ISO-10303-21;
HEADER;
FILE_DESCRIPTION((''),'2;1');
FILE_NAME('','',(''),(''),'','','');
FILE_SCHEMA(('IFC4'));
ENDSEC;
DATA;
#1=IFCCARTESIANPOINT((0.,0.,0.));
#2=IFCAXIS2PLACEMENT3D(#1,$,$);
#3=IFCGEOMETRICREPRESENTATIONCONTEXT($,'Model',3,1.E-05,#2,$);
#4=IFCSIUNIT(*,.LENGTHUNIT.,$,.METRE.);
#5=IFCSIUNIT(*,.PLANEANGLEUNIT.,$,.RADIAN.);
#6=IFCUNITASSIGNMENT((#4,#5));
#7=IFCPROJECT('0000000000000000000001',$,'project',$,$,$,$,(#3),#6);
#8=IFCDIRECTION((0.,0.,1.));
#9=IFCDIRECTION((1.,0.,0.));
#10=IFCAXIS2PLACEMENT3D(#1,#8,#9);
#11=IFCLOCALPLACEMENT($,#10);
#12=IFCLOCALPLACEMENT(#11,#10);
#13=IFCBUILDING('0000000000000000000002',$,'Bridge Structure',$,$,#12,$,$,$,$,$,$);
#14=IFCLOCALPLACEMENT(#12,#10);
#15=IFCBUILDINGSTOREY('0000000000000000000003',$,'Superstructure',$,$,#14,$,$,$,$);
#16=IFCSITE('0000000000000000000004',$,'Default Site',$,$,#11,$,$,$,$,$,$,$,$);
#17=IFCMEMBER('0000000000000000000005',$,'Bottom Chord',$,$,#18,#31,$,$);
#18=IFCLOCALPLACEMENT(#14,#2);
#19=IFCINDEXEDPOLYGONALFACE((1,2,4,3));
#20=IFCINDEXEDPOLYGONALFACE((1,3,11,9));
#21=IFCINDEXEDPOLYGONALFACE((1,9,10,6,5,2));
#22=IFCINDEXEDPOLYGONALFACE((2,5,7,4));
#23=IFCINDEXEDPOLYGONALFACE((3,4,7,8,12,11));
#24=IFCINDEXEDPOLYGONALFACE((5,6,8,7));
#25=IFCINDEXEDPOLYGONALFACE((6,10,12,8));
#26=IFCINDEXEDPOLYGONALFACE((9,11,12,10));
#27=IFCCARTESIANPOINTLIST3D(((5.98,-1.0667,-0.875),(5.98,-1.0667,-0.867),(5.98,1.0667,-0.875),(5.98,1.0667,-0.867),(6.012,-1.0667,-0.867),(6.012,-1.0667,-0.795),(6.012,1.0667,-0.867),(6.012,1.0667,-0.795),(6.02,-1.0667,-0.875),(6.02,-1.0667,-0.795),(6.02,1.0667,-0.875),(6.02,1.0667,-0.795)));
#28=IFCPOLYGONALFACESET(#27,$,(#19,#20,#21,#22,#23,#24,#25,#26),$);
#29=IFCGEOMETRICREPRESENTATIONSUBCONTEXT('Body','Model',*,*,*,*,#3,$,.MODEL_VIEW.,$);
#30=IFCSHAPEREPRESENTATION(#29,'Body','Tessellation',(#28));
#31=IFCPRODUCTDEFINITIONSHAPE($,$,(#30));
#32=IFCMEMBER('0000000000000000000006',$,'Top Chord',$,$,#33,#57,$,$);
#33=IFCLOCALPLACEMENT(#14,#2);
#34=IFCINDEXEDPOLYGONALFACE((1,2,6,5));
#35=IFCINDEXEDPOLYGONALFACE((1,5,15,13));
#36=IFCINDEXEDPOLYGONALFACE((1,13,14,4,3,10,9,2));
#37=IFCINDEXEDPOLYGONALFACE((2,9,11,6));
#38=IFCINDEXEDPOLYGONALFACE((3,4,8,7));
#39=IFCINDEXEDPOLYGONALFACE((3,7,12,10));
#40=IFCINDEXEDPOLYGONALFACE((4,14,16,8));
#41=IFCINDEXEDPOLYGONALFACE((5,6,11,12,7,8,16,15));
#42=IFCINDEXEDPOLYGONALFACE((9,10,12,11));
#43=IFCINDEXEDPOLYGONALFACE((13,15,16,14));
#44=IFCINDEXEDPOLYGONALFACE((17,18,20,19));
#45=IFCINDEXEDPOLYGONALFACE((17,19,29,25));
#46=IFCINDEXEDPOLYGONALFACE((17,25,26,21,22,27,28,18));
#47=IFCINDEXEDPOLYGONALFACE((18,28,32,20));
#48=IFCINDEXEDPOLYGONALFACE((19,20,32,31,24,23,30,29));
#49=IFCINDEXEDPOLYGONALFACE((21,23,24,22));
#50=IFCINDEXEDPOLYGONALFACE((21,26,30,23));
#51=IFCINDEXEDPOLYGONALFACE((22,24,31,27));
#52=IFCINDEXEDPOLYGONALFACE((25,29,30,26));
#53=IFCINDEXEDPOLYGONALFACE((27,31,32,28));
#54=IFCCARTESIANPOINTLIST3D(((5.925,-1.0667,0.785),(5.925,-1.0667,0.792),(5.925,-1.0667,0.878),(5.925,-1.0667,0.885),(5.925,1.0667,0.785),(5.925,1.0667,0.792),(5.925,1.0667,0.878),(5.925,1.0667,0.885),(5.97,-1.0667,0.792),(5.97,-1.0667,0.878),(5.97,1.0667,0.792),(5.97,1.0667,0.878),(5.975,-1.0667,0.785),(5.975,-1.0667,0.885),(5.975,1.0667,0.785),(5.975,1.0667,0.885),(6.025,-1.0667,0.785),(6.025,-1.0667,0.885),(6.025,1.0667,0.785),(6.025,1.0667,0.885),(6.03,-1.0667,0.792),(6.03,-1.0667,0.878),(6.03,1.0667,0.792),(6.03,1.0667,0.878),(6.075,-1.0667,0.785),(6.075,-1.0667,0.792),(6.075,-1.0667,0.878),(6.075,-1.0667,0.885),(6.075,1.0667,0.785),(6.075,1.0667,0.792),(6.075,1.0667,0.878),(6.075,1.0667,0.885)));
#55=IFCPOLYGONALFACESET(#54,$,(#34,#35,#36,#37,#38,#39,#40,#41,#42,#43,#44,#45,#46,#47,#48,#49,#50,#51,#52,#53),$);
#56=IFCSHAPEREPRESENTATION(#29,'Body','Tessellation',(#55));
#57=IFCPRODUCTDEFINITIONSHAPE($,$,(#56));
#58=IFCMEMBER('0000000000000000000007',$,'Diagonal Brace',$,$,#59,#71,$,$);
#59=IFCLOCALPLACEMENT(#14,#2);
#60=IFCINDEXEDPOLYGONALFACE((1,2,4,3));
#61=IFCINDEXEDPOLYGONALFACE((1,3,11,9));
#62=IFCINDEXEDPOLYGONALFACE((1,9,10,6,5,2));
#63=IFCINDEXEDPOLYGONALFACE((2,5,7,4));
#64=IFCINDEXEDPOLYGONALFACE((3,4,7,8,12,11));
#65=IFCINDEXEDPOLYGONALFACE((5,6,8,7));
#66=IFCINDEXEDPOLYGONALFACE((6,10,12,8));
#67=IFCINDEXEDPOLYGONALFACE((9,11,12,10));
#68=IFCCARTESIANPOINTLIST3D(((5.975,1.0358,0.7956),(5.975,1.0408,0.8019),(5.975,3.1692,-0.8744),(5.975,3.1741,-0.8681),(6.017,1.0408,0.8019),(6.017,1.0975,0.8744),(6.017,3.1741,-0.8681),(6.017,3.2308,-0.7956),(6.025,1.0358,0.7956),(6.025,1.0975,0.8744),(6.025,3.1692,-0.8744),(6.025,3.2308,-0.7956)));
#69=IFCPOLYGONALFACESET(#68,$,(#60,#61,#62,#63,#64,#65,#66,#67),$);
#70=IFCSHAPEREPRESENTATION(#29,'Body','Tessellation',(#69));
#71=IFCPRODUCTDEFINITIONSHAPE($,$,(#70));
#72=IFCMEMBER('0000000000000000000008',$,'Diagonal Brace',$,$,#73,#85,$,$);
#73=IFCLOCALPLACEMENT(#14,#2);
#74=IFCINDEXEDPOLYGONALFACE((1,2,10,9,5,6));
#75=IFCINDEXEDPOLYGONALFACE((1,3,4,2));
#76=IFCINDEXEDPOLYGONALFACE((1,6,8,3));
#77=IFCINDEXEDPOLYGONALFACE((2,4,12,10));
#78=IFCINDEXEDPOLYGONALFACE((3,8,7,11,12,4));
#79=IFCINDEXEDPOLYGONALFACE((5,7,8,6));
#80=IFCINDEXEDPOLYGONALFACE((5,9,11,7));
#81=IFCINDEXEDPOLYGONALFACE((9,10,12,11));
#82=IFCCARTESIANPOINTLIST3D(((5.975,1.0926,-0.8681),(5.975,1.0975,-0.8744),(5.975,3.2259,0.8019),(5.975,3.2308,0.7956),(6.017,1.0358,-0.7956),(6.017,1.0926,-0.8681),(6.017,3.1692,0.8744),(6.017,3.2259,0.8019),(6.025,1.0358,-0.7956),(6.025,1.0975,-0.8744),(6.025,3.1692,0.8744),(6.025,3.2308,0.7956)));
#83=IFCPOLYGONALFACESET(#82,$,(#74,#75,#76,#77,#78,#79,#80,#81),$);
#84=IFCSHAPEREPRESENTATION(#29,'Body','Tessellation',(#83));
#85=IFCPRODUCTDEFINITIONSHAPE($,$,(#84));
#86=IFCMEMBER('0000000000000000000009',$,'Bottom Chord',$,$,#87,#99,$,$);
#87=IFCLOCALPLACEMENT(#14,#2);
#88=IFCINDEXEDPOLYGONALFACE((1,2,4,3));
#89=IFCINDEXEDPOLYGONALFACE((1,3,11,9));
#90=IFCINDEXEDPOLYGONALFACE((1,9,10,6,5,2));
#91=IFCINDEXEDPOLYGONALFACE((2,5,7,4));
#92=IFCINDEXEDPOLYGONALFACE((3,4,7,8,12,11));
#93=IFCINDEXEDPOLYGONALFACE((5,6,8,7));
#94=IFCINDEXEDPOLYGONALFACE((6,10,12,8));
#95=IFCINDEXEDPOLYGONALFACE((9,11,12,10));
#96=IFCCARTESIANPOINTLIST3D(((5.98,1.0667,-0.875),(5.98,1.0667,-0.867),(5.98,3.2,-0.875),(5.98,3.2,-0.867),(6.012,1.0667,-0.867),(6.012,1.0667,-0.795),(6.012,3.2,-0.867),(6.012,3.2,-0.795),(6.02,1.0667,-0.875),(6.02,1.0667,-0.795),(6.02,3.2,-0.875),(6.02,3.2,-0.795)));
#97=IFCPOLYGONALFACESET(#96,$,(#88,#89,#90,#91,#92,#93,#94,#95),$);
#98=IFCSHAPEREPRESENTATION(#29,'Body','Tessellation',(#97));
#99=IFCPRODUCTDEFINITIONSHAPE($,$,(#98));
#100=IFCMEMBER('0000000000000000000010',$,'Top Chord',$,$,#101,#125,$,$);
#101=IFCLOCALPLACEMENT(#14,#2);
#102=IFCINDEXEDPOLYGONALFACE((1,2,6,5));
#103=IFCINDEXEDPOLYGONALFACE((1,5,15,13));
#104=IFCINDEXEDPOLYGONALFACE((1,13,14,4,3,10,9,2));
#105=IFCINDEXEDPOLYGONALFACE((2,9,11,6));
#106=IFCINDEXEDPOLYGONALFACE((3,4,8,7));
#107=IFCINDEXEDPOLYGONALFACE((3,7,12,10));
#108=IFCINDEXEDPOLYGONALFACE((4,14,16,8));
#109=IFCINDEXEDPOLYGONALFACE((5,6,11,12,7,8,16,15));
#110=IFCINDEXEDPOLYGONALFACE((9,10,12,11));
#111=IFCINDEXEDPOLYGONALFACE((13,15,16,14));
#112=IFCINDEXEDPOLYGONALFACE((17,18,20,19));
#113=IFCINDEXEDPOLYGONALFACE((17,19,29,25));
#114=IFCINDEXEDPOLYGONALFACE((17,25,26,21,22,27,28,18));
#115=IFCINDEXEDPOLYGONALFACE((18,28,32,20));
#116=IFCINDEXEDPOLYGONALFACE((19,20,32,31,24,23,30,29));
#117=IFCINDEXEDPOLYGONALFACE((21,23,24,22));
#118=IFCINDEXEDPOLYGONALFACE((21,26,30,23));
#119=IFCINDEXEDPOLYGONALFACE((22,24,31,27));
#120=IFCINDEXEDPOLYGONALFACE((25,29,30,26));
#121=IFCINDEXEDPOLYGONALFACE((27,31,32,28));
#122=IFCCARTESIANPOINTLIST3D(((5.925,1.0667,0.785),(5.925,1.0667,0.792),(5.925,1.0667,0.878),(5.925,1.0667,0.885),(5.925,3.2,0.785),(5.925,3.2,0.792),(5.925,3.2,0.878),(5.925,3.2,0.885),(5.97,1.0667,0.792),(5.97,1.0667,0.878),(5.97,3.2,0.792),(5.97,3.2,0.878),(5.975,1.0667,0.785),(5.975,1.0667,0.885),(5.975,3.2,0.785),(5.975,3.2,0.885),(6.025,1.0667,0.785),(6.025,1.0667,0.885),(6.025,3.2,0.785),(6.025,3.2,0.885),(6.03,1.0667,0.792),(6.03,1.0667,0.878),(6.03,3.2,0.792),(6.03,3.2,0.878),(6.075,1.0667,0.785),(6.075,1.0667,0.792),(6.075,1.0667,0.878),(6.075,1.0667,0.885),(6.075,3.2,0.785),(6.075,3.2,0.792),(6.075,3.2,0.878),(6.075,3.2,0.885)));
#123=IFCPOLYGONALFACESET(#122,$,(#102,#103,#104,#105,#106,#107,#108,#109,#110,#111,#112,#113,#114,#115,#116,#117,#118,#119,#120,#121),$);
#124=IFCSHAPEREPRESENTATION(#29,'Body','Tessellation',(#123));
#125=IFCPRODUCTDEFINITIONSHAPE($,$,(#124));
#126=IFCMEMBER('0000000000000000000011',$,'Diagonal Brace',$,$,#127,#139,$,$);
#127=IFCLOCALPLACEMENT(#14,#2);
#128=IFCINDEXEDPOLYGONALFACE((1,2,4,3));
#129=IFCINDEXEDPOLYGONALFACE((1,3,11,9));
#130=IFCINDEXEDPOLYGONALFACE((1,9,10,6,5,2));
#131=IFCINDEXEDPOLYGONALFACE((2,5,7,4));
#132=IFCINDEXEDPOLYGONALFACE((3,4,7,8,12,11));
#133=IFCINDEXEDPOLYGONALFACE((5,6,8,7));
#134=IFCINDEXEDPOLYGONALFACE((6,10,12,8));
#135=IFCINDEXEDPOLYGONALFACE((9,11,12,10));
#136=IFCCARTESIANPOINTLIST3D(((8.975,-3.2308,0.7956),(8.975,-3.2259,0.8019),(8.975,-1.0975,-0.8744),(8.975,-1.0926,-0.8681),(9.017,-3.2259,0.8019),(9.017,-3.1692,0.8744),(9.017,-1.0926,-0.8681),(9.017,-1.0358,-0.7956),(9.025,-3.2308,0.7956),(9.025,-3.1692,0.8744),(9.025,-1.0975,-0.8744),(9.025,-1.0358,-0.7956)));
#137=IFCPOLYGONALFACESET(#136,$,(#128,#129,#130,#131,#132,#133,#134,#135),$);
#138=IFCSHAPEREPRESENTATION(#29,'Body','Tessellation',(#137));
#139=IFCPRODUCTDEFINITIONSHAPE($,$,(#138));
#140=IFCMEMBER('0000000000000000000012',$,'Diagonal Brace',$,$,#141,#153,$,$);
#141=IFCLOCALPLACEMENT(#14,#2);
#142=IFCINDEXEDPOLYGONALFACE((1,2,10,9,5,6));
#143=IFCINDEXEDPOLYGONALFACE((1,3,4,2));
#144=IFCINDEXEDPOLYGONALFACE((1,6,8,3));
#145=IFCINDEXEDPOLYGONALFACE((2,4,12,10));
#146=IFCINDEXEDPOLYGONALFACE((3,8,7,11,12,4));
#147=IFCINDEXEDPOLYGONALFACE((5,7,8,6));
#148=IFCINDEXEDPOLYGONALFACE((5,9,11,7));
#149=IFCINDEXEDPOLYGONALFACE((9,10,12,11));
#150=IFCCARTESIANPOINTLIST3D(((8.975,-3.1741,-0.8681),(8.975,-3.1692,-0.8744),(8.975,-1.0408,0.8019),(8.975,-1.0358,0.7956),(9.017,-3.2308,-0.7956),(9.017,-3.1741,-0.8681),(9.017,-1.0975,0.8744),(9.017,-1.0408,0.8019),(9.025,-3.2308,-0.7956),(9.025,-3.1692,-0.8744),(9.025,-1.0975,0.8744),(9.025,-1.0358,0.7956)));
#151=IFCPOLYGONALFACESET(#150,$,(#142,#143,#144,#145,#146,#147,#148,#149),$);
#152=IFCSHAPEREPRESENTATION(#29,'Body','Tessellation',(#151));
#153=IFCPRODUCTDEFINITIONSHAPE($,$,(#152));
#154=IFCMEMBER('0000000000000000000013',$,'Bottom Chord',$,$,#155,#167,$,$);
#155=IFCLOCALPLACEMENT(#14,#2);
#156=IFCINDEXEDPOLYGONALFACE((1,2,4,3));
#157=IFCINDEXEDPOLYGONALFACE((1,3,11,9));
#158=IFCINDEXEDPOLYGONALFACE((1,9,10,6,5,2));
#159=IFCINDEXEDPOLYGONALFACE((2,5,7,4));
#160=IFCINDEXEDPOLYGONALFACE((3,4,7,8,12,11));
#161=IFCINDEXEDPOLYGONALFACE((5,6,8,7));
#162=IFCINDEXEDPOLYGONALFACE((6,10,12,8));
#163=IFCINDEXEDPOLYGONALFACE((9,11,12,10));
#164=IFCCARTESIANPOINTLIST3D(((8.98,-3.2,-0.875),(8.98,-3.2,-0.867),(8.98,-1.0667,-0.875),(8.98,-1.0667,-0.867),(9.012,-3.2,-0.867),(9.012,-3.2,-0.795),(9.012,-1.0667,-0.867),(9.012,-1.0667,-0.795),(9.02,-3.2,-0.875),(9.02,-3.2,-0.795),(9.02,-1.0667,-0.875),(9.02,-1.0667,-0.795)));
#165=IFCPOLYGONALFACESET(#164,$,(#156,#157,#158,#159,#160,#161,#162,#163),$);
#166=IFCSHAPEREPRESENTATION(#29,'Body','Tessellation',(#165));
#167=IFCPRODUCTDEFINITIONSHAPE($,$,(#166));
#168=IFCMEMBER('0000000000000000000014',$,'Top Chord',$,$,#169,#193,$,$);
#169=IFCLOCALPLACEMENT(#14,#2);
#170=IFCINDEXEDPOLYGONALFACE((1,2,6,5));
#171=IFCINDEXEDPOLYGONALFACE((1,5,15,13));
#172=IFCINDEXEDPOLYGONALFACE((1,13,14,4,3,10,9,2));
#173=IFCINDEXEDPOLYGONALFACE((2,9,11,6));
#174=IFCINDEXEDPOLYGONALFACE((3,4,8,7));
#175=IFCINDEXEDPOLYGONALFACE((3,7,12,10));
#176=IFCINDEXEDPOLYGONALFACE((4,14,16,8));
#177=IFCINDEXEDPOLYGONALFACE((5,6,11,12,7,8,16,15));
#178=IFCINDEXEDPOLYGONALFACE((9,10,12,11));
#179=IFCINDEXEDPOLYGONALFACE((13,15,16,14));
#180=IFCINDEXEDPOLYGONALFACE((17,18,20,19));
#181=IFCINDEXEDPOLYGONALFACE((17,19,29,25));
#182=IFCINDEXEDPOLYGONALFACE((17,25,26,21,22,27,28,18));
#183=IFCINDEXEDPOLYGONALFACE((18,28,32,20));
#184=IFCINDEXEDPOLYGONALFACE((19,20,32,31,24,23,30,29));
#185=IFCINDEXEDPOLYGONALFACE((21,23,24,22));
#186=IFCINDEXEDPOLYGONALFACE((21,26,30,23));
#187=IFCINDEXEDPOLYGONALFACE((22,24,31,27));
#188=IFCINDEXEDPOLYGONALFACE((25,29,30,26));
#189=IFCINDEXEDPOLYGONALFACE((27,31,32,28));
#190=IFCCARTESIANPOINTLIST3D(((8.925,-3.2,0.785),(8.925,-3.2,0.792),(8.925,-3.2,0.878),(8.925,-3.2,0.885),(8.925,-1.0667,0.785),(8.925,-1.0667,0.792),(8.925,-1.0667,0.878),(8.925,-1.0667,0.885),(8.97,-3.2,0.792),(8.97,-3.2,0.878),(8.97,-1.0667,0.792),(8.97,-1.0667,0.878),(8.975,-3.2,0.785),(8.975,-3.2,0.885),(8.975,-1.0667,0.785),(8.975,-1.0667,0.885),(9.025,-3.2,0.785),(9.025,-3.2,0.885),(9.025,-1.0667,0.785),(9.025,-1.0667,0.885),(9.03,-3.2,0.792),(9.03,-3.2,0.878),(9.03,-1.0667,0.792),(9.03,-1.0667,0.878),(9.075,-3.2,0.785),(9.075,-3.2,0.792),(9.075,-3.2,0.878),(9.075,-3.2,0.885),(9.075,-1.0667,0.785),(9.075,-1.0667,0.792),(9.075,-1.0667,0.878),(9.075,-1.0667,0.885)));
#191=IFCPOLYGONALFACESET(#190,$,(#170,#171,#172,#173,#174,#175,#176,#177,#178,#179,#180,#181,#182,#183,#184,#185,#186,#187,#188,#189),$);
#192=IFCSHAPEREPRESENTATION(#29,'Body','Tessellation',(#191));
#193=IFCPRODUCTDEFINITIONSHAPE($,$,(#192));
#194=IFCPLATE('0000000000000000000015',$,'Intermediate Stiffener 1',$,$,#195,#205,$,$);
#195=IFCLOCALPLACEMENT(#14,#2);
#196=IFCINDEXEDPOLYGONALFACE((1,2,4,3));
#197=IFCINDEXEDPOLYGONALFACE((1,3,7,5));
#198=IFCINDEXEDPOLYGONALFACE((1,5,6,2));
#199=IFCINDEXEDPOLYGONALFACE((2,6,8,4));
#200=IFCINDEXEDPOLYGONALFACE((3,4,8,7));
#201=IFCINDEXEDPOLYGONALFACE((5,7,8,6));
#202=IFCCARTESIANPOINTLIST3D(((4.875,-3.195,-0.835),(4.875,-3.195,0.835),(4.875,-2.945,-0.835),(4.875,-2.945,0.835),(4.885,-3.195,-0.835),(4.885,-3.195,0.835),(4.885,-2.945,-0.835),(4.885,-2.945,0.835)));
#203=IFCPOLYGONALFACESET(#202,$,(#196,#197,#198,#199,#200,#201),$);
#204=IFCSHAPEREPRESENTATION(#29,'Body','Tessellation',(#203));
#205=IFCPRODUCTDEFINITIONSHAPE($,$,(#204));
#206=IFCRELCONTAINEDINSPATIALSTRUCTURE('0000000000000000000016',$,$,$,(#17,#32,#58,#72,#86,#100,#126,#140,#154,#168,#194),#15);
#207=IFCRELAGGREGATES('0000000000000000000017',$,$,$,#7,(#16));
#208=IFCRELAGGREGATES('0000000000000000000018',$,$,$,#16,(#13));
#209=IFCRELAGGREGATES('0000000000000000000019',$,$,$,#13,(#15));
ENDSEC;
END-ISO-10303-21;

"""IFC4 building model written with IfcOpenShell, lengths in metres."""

from ifc_helpers import new_model, si_unit, frame, origin, origin_with_axes, origin_2d_with_axis, place, context, subcontext, project, spatial, polyline, rectangle, l_section, outline, composite_profile, extrude, element, save


model = new_model("IFC4")

# Units and contexts
model_context = context("Model", 3, precision=1e-05, world=origin())
body_context = subcontext(model_context, "Body", "Model", "MODEL_VIEW")
ifc_project = project(units=[si_unit("LENGTHUNIT", "METRE"), si_unit("PLANEANGLEUNIT", "RADIAN")], contexts=[model_context])

# Site, building, storey
site_placement = place(None, origin_with_axes())
site = spatial("IfcSite", under=ifc_project, at=site_placement, Name="Default Site")
building_placement = place(site_placement, origin_with_axes())
building = spatial("IfcBuilding", under=site, at=building_placement, Name="Bridge Structure")
storey_placement = place(building_placement, origin_with_axes())
storey = spatial("IfcBuildingStorey", under=building, at=storey_placement, Name="Superstructure")

# Members
member_1_placement = place(storey_placement, frame((6.0, -1.0667, -0.835), z_axis=(0.0, 1.0, 0.0), x_axis=(-1.0, 0.0, 0.0)))
element("IfcMember", 1, at=member_1_placement, inside=storey, Name="Bottom Chord", context=body_context, shape_type="SweptSolid", body=[
    extrude(l_section(Depth=0.08, Width=0.04, Thickness=0.008, at=origin_2d_with_axis()), origin_with_axes(), (0.0, 0.0, 1.0), 2.1333),
])
member_2_placement = place(storey_placement, frame((6.0, -1.0667, 0.835), z_axis=(0.0, 1.0, 0.0), x_axis=(-1.0, 0.0, 0.0)))
element("IfcMember", 2, at=member_2_placement, inside=storey, Name="Top Chord", context=body_context, shape_type="SweptSolid", body=[
    extrude(composite_profile([outline(polyline([(-0.025, -0.05), (-0.025, 0.05), (-0.075, 0.05), (-0.075, 0.043), (-0.03, 0.043), (-0.03, -0.043), (-0.075, -0.043), (-0.075, -0.05), (-0.025, -0.05)])), outline(polyline([(0.025, -0.05), (0.075, -0.05), (0.075, -0.043), (0.03, -0.043), (0.03, 0.043), (0.075, 0.043), (0.075, 0.05), (0.025, 0.05), (0.025, -0.05)]))]), origin_with_axes(), (0.0, 0.0, 1.0), 2.1333),
])
for number, where, z_axis, x_axis, name in (
    (3, (6.0, 1.0667, 0.835), (0.0, 0.787427, -0.616408), (-1.0, 0.0, 0.0), "Diagonal Brace"),
    (4, (6.0, 1.0667, -0.835), (0.0, 0.787427, 0.616408), (-1.0, 0.0, 0.0), "Diagonal Brace"),
):
    element("IfcMember", number, at=place(storey_placement, frame(where, z_axis=z_axis, x_axis=x_axis)), inside=storey, Name=name, context=body_context, shape_type="SweptSolid", body=[
        extrude(l_section(Depth=0.1, Width=0.05, Thickness=0.008, at=origin_2d_with_axis()), origin_with_axes(), (0.0, 0.0, 1.0), 2.7092),
    ])
member_3_placement = place(storey_placement, frame((6.0, 1.0667, -0.835), z_axis=(0.0, 1.0, 0.0), x_axis=(-1.0, 0.0, 0.0)))
element("IfcMember", 5, at=member_3_placement, inside=storey, Name="Bottom Chord", context=body_context, shape_type="SweptSolid", body=[
    extrude(l_section(Depth=0.08, Width=0.04, Thickness=0.008, at=origin_2d_with_axis()), origin_with_axes(), (0.0, 0.0, 1.0), 2.1333),
])
member_4_placement = place(storey_placement, frame((6.0, 1.0667, 0.835), z_axis=(0.0, 1.0, 0.0), x_axis=(-1.0, 0.0, 0.0)))
element("IfcMember", 6, at=member_4_placement, inside=storey, Name="Top Chord", context=body_context, shape_type="SweptSolid", body=[
    extrude(composite_profile([outline(polyline([(-0.025, -0.05), (-0.025, 0.05), (-0.075, 0.05), (-0.075, 0.043), (-0.03, 0.043), (-0.03, -0.043), (-0.075, -0.043), (-0.075, -0.05), (-0.025, -0.05)])), outline(polyline([(0.025, -0.05), (0.075, -0.05), (0.075, -0.043), (0.03, -0.043), (0.03, 0.043), (0.075, 0.043), (0.075, 0.05), (0.025, 0.05), (0.025, -0.05)]))]), origin_with_axes(), (0.0, 0.0, 1.0), 2.1333),
])
for number, where, z_axis, x_axis, name in (
    (7, (9.0, -3.2, 0.835), (0.0, 0.787427, -0.616408), (-1.0, 0.0, 0.0), "Diagonal Brace"),
    (8, (9.0, -3.2, -0.835), (0.0, 0.787427, 0.616408), (-1.0, 0.0, 0.0), "Diagonal Brace"),
):
    element("IfcMember", number, at=place(storey_placement, frame(where, z_axis=z_axis, x_axis=x_axis)), inside=storey, Name=name, context=body_context, shape_type="SweptSolid", body=[
        extrude(l_section(Depth=0.1, Width=0.05, Thickness=0.008, at=origin_2d_with_axis()), origin_with_axes(), (0.0, 0.0, 1.0), 2.7092),
    ])
member_5_placement = place(storey_placement, frame((9.0, -3.2, -0.835), z_axis=(0.0, 1.0, 0.0), x_axis=(-1.0, 0.0, 0.0)))
element("IfcMember", 9, at=member_5_placement, inside=storey, Name="Bottom Chord", context=body_context, shape_type="SweptSolid", body=[
    extrude(l_section(Depth=0.08, Width=0.04, Thickness=0.008, at=origin_2d_with_axis()), origin_with_axes(), (0.0, 0.0, 1.0), 2.1333),
])
member_6_placement = place(storey_placement, frame((9.0, -3.2, 0.835), z_axis=(0.0, 1.0, 0.0), x_axis=(-1.0, 0.0, 0.0)))
element("IfcMember", 10, at=member_6_placement, inside=storey, Name="Top Chord", context=body_context, shape_type="SweptSolid", body=[
    extrude(composite_profile([outline(polyline([(-0.025, -0.05), (-0.025, 0.05), (-0.075, 0.05), (-0.075, 0.043), (-0.03, 0.043), (-0.03, -0.043), (-0.075, -0.043), (-0.075, -0.05), (-0.025, -0.05)])), outline(polyline([(0.025, -0.05), (0.075, -0.05), (0.075, -0.043), (0.03, -0.043), (0.03, 0.043), (0.075, 0.043), (0.075, 0.05), (0.025, 0.05), (0.025, -0.05)]))]), origin_with_axes(), (0.0, 0.0, 1.0), 2.1333),
])

# Plate
for number, where, z_axis, x_axis, name in (
    (11, (4.88, -3.07, -0.835), (0.0, 0.0, 1.0), (1.0, 0.0, 0.0), "Intermediate Stiffener 1"),
):
    element("IfcPlate", number, at=place(storey_placement, frame(where, z_axis=z_axis, x_axis=x_axis)), inside=storey, Name=name, context=body_context, shape_type="SweptSolid", body=[
        extrude(rectangle(XDim=0.01, YDim=0.25, at=origin_2d_with_axis()), origin_with_axes(), (0.0, 0.0, 1.0), 1.67),
    ])

save(model, "model.ifc")
